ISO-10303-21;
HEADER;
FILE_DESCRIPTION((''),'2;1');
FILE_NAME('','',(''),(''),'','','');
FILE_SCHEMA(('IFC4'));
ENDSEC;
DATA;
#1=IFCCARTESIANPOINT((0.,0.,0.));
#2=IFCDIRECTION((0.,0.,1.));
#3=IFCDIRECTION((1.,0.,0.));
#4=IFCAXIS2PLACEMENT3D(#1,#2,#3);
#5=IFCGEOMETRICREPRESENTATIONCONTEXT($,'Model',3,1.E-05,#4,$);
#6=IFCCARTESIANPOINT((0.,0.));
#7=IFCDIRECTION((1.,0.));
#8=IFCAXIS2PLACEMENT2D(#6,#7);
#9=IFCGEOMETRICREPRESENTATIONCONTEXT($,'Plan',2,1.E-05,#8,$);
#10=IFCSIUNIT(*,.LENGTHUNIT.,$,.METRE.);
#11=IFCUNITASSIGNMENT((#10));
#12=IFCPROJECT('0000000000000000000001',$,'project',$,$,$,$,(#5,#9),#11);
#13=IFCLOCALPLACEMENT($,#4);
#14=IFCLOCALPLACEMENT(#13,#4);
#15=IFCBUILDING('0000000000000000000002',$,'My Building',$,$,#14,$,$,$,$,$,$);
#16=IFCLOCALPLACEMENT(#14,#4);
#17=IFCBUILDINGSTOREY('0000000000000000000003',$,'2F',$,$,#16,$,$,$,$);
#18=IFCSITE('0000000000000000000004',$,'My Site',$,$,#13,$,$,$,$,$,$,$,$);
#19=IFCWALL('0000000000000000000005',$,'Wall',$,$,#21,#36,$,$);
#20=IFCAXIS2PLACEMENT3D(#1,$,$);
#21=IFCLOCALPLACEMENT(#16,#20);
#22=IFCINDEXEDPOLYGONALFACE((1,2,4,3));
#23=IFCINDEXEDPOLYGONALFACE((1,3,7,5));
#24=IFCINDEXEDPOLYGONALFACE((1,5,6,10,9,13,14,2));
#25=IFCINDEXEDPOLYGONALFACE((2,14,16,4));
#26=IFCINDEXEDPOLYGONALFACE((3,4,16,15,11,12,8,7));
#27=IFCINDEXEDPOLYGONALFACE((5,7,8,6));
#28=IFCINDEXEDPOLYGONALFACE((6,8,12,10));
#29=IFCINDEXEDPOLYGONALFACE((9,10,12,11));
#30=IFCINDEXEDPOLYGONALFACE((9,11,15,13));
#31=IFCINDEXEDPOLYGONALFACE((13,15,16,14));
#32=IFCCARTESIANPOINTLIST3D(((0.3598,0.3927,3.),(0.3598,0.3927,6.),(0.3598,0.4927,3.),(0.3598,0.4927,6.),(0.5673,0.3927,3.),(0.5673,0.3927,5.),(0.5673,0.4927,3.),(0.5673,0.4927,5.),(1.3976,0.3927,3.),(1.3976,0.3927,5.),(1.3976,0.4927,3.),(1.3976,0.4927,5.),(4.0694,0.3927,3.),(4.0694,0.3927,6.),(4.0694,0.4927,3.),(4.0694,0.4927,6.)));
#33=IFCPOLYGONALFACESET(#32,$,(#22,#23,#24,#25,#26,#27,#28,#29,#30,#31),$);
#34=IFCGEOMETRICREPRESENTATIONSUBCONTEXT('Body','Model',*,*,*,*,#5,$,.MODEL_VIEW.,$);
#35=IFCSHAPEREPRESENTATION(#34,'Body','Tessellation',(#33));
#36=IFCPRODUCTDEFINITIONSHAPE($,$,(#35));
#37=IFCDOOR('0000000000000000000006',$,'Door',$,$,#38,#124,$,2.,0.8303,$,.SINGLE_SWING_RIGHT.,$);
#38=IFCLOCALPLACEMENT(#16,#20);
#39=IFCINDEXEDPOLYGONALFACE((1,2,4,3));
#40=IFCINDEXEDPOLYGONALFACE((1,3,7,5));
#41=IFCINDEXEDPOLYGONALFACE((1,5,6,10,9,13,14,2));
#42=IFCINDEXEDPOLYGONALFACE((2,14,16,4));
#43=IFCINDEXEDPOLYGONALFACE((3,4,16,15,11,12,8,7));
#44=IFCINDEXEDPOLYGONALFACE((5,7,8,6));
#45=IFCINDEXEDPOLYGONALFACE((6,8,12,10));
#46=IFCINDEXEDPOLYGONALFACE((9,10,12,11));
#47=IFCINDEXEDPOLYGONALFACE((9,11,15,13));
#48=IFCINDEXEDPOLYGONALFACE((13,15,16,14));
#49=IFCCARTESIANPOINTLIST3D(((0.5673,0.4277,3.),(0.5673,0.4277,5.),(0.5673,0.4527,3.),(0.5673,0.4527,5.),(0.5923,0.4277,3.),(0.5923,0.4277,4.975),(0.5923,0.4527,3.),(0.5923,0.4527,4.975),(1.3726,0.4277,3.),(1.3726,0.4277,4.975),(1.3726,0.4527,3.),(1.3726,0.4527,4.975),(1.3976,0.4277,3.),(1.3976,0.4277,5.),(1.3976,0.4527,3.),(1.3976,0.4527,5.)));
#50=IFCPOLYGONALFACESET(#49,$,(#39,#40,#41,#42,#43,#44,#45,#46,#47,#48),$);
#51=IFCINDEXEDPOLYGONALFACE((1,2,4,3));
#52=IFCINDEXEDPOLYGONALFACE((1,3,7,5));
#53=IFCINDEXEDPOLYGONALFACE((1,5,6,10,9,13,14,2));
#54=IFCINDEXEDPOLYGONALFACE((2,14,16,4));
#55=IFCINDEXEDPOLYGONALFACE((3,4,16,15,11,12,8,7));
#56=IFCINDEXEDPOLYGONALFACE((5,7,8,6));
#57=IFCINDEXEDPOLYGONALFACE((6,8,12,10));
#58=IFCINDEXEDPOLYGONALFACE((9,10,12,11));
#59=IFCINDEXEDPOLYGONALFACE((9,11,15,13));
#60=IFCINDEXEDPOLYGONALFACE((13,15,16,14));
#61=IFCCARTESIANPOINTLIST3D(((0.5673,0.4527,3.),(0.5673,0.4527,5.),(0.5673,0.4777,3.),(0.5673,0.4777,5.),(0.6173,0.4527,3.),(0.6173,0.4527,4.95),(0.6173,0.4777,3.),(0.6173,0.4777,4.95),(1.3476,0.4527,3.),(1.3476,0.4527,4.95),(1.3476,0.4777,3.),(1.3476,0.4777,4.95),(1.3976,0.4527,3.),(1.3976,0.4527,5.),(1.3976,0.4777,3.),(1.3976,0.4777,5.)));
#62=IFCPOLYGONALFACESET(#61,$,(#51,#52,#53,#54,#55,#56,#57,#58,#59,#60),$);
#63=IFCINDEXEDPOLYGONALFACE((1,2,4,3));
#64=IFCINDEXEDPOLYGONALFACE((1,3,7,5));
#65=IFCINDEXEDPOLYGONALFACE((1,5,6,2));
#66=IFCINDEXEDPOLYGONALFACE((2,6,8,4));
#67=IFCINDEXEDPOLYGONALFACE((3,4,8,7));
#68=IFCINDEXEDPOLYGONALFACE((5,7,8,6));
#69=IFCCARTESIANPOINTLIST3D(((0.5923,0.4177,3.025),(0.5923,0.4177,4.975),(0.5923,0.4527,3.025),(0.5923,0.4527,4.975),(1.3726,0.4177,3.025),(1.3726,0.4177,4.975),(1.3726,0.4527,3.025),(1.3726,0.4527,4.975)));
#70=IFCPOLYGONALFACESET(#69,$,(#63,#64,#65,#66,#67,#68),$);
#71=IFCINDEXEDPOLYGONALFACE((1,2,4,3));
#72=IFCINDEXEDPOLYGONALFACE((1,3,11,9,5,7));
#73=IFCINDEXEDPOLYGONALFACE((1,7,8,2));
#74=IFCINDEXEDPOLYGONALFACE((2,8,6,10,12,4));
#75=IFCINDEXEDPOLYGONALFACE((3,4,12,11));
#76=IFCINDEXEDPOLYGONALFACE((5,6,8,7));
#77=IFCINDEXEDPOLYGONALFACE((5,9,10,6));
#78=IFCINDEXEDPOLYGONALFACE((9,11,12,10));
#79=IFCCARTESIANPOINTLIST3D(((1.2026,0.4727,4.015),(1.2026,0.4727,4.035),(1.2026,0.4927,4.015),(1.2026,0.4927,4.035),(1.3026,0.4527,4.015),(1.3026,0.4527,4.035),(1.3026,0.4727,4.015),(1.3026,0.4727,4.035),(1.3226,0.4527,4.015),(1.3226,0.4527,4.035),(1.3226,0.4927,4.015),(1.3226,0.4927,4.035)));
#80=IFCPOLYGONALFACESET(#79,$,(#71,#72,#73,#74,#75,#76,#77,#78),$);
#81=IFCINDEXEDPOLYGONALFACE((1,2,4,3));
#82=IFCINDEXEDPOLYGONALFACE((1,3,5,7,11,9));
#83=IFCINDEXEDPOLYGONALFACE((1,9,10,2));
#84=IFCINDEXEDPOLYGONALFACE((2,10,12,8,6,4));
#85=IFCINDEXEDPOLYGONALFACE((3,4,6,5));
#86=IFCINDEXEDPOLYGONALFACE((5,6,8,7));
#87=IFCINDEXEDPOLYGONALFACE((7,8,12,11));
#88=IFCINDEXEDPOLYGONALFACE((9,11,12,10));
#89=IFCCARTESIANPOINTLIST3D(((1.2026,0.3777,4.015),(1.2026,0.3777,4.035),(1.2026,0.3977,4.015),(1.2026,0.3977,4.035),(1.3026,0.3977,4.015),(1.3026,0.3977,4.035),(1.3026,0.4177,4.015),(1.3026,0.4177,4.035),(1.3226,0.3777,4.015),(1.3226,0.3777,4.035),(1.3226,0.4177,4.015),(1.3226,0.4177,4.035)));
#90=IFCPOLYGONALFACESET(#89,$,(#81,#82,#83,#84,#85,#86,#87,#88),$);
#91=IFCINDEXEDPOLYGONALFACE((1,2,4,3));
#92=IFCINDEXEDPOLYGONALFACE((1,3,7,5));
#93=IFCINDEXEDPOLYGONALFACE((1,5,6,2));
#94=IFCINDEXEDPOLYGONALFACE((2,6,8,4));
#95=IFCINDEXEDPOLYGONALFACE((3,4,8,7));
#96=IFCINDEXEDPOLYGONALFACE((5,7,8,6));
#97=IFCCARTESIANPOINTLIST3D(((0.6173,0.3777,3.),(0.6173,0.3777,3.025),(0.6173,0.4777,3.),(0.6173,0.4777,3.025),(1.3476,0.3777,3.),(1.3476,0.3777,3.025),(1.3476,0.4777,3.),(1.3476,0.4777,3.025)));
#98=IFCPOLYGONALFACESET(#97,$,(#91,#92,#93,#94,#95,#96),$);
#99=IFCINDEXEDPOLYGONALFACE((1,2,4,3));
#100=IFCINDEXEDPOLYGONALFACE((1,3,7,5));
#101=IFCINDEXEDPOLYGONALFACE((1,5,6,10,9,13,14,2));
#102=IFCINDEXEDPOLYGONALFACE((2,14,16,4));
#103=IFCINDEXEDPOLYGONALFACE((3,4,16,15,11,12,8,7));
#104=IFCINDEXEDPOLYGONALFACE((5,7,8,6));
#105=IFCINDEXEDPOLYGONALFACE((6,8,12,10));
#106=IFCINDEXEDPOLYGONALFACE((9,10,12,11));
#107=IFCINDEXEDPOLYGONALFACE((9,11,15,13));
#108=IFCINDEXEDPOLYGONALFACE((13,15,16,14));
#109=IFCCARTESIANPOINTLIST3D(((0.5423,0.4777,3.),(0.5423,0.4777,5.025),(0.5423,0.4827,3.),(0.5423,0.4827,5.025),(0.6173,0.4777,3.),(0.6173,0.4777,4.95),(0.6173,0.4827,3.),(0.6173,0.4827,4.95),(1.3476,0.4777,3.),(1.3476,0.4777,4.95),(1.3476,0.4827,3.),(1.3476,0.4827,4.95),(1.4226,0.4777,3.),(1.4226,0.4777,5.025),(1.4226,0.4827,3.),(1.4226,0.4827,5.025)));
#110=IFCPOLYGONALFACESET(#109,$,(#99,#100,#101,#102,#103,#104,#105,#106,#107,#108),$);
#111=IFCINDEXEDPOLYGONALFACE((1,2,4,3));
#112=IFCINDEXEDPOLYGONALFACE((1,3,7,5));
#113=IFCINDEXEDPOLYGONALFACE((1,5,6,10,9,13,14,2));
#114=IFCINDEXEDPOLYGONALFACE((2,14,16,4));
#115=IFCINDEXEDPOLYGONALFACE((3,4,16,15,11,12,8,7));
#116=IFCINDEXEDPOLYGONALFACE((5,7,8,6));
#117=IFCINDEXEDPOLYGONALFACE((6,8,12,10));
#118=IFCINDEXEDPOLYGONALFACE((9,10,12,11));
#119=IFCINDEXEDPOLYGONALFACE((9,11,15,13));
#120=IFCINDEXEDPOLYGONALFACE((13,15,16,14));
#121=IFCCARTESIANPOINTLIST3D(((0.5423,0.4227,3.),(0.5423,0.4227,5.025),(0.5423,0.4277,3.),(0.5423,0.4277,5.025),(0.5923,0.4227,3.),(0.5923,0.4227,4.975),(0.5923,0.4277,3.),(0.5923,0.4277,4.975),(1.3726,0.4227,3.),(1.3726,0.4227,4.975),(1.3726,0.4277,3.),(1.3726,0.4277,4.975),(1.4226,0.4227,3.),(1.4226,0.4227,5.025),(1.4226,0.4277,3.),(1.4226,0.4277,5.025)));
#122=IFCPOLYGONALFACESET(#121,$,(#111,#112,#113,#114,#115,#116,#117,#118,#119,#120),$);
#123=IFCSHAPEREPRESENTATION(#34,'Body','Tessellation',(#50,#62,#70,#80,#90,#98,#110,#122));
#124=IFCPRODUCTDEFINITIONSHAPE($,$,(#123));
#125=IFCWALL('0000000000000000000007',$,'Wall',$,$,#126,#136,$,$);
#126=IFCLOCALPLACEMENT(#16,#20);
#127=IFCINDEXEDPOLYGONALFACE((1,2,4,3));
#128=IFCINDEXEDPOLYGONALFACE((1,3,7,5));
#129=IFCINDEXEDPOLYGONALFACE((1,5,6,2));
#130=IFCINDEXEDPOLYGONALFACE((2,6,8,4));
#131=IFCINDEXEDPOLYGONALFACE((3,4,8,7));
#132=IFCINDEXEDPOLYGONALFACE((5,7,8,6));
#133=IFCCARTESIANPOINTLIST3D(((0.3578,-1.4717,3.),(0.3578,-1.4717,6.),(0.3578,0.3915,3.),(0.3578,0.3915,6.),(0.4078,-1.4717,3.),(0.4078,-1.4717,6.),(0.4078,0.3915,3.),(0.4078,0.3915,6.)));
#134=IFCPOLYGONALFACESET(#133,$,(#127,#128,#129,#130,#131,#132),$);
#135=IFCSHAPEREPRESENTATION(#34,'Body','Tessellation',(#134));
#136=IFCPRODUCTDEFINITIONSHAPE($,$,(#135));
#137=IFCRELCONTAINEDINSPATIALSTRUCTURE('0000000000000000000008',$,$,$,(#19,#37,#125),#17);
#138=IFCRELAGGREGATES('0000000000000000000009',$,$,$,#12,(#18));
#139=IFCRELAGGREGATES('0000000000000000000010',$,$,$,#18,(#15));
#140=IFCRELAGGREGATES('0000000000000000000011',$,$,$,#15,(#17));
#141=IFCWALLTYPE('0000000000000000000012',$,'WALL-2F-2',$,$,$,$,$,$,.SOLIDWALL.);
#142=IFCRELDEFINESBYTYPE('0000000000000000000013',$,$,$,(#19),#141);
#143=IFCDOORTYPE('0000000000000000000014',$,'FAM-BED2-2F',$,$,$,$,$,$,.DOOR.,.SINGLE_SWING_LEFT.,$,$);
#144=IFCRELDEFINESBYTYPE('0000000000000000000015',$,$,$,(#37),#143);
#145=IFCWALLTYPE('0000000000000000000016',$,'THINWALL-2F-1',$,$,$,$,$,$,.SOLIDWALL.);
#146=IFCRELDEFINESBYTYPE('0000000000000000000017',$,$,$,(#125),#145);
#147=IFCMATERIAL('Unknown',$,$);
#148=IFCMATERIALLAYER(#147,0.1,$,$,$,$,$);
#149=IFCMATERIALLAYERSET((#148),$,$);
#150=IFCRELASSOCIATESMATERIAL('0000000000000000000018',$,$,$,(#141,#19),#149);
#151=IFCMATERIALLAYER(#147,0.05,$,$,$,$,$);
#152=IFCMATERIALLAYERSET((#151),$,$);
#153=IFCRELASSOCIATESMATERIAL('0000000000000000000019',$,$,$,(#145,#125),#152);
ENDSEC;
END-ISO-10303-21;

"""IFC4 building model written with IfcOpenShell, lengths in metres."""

from ifc_helpers import new_model, entity, si_unit, frame, origin_with_axes, origin_2d_with_axis, place, context, subcontext, project, spatial, line, indexed_curve, outline, extrude, shape, source, transform, mapped, material, layer, layer_set, layer_usage, type_object, type_shapes, element, fill, save


model = new_model("IFC4")

# Units and contexts
model_context = context("Model", 3, precision=1e-05, world=origin_with_axes())
plan_context = context("Plan", 2, precision=1e-05, world=origin_2d_with_axis())
body_context_1 = subcontext(model_context, "Body", "Model", "MODEL_VIEW")
body_context_2 = subcontext(plan_context, "Body", "Plan", "PLAN_VIEW")
ifc_project = project(units=[si_unit("LENGTHUNIT", "METRE")], contexts=[model_context, plan_context])

# Site, building, storey
site_placement = place(None, origin_with_axes())
site = spatial("IfcSite", under=ifc_project, at=site_placement, Name="My Site")
building_placement = place(site_placement, origin_with_axes())
building = spatial("IfcBuilding", under=site, at=building_placement, Name="My Building")
storey_placement = place(building_placement, origin_with_axes())
storey = spatial("IfcBuildingStorey", under=building, at=storey_placement, Name="2F")

# Shared definitions
ifc_material = material(Name="Unknown")

# Shared definitions
ifc_layer_1 = layer(ifc_material, 0.1)
ifc_layer_set_1 = layer_set([ifc_layer_1])
wall_type_1 = type_object("IfcWallType", Name="WALL-2F-2", PredefinedType="SOLIDWALL", material=ifc_layer_set_1)

# Wall, opening, door
ifc_layer_usage_1 = layer_usage(ifc_layer_set_1, "AXIS2", "POSITIVE", 0.0)
wall_1_placement = place(storey_placement, frame((4.0694, 0.4927, 3.0), z_axis=(0.0, 0.0, 1.0), x_axis=(-1.0, 0.0, 0.0)))
wall_1 = element("IfcWall", 1, at=wall_1_placement, inside=storey, type_object=wall_type_1, material=ifc_layer_usage_1, Name="Wall", context=body_context_1, shape_type="SweptSolid", body=[
    extrude(outline(indexed_curve([(0.0, 0.0), (0.0, 0.1), (3.7096, 0.1), (3.7096, 0.0)], segments=[line(1, 2, 3, 4, 1)])), origin_with_axes(), (0.0, 0.0, 1.0), 3.0),
])
shared_shape_1 = source(origin_with_axes(), body_context_1, "Body", "SweptSolid", [
    extrude(outline(indexed_curve([(0.0, 0.0), (0.8303, 0.0), (0.8303, 2.0), (0.0, 2.0)], segments=[line(1, 2, 3, 4, 1)])), frame((0.0, -0.6, 0.0), z_axis=(0.0, -1.0, 0.0), x_axis=(1.0, 0.0, 0.0)), (0.0, 0.0, -1.0), 1.2),
])
opening_1_placement = place(wall_1_placement, frame((2.6718, 0.015, 0.0), z_axis=(0.0, 0.0, 1.0), x_axis=(1.0, 0.0, 0.0)))
opening_1 = element("IfcOpeningElement", 2, at=opening_1_placement, cuts=wall_1, PredefinedType="OPENING", context=body_context_1, shape_type="MappedRepresentation", body=[
    mapped(shared_shape_1, transform((0.0, 0.0, 0.0), x_axis=(1.0, 0.0, 0.0), y_axis=(0.0, 1.0, 0.0), z_axis=(0.0, 0.0, 1.0), scale=1.0)),
])
door_type_1 = type_object("IfcDoorType", Name="FAM-BED2-2F", OperationType="SINGLE_SWING_LEFT", PredefinedType="DOOR")
shared_shape_2 = source(origin_with_axes(), body_context_1, "Body", "SweptSolid", [
    extrude(outline(indexed_curve([(0.0, 0.0), (0.0, 2.0), (0.8303, 2.0), (0.8303, 0.0), (0.8053, 0.0), (0.8053, 1.975), (0.025, 1.975), (0.025, 0.0)], segments=[line(1, 2, 3, 4, 5, 6, 7, 8, 1)])), frame((0.0, 0.025, 0.0), z_axis=(0.0, -1.0, 0.0), x_axis=(1.0, 0.0, 0.0)), (0.0, 0.0, -1.0), 0.025),
    extrude(outline(indexed_curve([(0.0, 0.0), (0.0, 2.0), (0.8303, 2.0), (0.8303, 0.0), (0.7803, 0.0), (0.7803, 1.95), (0.05, 1.95), (0.05, 0.0)], segments=[line(1, 2, 3, 4, 5, 6, 7, 8, 1)])), frame((0.0, 0.0, 0.0), z_axis=(0.0, -1.0, 0.0), x_axis=(1.0, 0.0, 0.0)), (0.0, 0.0, -1.0), 0.025),
    extrude(outline(indexed_curve([(0.0, 0.0), (0.7803, 0.0), (0.7803, 0.035), (0.0, 0.035)], segments=[line(1, 2, 3, 4, 1)])), frame((0.025, 0.025, 0.025), z_axis=(0.0, 0.0, 1.0), x_axis=(1.0, 0.0, 0.0)), (0.0, 0.0, 1.0), 1.95),
    extrude(outline(indexed_curve([(0.0, 0.0), (0.0, -0.04), (0.12, -0.04), (0.12, -0.02), (0.02, -0.02), (0.02, 0.0)], segments=[line(1, 2, 3, 4, 5, 6, 1)])), frame((0.075, 0.025, 1.015), z_axis=(0.0, 0.0, 1.0), x_axis=(1.0, 0.0, 0.0)), (0.0, 0.0, 1.0), 0.02),
    extrude(outline(indexed_curve([(0.0, 0.0), (0.0, 0.04), (0.12, 0.04), (0.12, 0.02), (0.02, 0.02), (0.02, 0.0)], segments=[line(1, 2, 3, 4, 5, 6, 1)])), frame((0.075, 0.06, 1.015), z_axis=(0.0, 0.0, 1.0), x_axis=(1.0, 0.0, 0.0)), (0.0, 0.0, 1.0), 0.02),
    extrude(outline(indexed_curve([(0.0, 0.0), (0.7303, 0.0), (0.7303, 0.1), (0.0, 0.1)], segments=[line(1, 2, 3, 4, 1)])), frame((0.05, 0.0, 0.0), z_axis=(0.0, 0.0, 1.0), x_axis=(1.0, 0.0, 0.0)), (0.0, 0.0, 1.0), 0.025),
    extrude(outline(indexed_curve([(0.0, 0.0), (0.0, 2.025), (0.8803, 2.025), (0.8803, 0.0), (0.8053, 0.0), (0.8053, 1.95), (0.075, 1.95), (0.075, 0.0)], segments=[line(1, 2, 3, 4, 5, 6, 7, 8, 1)])), frame((-0.025, -0.005, 0.0), z_axis=(0.0, -1.0, 0.0), x_axis=(1.0, 0.0, 0.0)), (0.0, 0.0, -1.0), 0.005),
    extrude(outline(indexed_curve([(0.0, 0.0), (0.0, 2.025), (0.8803, 2.025), (0.8803, 0.0), (0.8303, 0.0), (0.8303, 1.975), (0.05, 1.975), (0.05, 0.0)], segments=[line(1, 2, 3, 4, 5, 6, 7, 8, 1)])), frame((-0.025, 0.05, 0.0), z_axis=(0.0, -1.0, 0.0), x_axis=(1.0, 0.0, 0.0)), (0.0, 0.0, -1.0), 0.005),
])
shared_shape_3 = source(origin_with_axes(), body_context_2, "Body", "Curve2D", [
    entity("IfcIndexedPolyCurve", entity("IfcCartesianPointList2D", [[0.0, 0.0], [0.0, 0.05], [0.025, 0.05], [0.025, 0.025], [0.05, 0.025], [0.05, 0.0]]), [entity("IfcLineIndex", [1, 2, 3, 4, 5, 6, 1])]),
    entity("IfcIndexedPolyCurve", entity("IfcCartesianPointList2D", [[0.8303, 0.0], [0.8303, 0.05], [0.8053, 0.05], [0.8053, 0.025], [0.7803, 0.025], [0.7803, 0.0]]), [entity("IfcLineIndex", [1, 2, 3, 4, 5, 6, 1])]),
    entity("IfcTrimmedCurve", entity("IfcEllipse", entity("IfcAxis2Placement2D", entity("IfcCartesianPoint", [0.7703, 0.05]), entity("IfcDirection", [1.0, 0.0])), 0.7453, 0.7803), [entity("IfcCartesianPoint", [0.7703, 0.8303])], [entity("IfcCartesianPoint", [0.025, 0.05])], True, "CARTESIAN"),
    entity("IfcIndexedPolyCurve", entity("IfcCartesianPointList2D", [[0.8053, 0.05], [0.7703, 0.05], [0.7703, 0.8303], [0.8053, 0.8303]]), [entity("IfcLineIndex", [1, 2, 3, 4, 1])]),
])
type_shapes(door_type_1, [shared_shape_2, shared_shape_3])
door_1_placement = place(opening_1_placement, frame((0.0, 0.0, 0.0), z_axis=(0.0, 0.0, 1.0), x_axis=(1.0, 0.0, 0.0)))
door_1 = element("IfcDoor", 3, at=door_1_placement, inside=storey, type_object=door_type_1, Name="Door", OperationType="SINGLE_SWING_RIGHT", OverallHeight=2.0, OverallWidth=0.8303, shapes=[
    shape(body_context_1, "Body", "MappedRepresentation", [mapped(shared_shape_2, transform((0.0, 0.0, 0.0), x_axis=(1.0, 0.0, 0.0), y_axis=(0.0, 1.0, 0.0), z_axis=(0.0, 0.0, 1.0), scale=1.0))]),
    shape(body_context_2, "Body", "MappedRepresentation", [mapped(shared_shape_3, transform((0.0, 0.0, 0.0), x_axis=(1.0, 0.0, 0.0), y_axis=(0.0, 1.0, 0.0), z_axis=(0.0, 0.0, 1.0), scale=1.0))]),
])
fill(opening_1, door_1)

# Wall
ifc_layer_2 = layer(ifc_material, 0.05)
ifc_layer_set_2 = layer_set([ifc_layer_2])
ifc_layer_usage_2 = layer_usage(ifc_layer_set_2, "AXIS2", "POSITIVE", 0.0)
wall_type_2 = type_object("IfcWallType", Name="THINWALL-2F-1", PredefinedType="SOLIDWALL", material=ifc_layer_set_2)
wall_2_placement = place(storey_placement, frame((0.4078, -1.4717, 3.0), z_axis=(0.0, 0.0, 1.0), x_axis=(0.0, 1.0, 0.0)))
element("IfcWall", 4, at=wall_2_placement, inside=storey, type_object=wall_type_2, material=ifc_layer_usage_2, Name="Wall", context=body_context_1, shape_type="SweptSolid", body=[
    extrude(outline(indexed_curve([(0.0, 0.0), (0.0, 0.05), (1.8632, 0.05), (1.8632, 0.0)], segments=[line(1, 2, 3, 4, 1)])), origin_with_axes(), (0.0, 0.0, 1.0), 3.0),
])

save(model, "model.ifc")
